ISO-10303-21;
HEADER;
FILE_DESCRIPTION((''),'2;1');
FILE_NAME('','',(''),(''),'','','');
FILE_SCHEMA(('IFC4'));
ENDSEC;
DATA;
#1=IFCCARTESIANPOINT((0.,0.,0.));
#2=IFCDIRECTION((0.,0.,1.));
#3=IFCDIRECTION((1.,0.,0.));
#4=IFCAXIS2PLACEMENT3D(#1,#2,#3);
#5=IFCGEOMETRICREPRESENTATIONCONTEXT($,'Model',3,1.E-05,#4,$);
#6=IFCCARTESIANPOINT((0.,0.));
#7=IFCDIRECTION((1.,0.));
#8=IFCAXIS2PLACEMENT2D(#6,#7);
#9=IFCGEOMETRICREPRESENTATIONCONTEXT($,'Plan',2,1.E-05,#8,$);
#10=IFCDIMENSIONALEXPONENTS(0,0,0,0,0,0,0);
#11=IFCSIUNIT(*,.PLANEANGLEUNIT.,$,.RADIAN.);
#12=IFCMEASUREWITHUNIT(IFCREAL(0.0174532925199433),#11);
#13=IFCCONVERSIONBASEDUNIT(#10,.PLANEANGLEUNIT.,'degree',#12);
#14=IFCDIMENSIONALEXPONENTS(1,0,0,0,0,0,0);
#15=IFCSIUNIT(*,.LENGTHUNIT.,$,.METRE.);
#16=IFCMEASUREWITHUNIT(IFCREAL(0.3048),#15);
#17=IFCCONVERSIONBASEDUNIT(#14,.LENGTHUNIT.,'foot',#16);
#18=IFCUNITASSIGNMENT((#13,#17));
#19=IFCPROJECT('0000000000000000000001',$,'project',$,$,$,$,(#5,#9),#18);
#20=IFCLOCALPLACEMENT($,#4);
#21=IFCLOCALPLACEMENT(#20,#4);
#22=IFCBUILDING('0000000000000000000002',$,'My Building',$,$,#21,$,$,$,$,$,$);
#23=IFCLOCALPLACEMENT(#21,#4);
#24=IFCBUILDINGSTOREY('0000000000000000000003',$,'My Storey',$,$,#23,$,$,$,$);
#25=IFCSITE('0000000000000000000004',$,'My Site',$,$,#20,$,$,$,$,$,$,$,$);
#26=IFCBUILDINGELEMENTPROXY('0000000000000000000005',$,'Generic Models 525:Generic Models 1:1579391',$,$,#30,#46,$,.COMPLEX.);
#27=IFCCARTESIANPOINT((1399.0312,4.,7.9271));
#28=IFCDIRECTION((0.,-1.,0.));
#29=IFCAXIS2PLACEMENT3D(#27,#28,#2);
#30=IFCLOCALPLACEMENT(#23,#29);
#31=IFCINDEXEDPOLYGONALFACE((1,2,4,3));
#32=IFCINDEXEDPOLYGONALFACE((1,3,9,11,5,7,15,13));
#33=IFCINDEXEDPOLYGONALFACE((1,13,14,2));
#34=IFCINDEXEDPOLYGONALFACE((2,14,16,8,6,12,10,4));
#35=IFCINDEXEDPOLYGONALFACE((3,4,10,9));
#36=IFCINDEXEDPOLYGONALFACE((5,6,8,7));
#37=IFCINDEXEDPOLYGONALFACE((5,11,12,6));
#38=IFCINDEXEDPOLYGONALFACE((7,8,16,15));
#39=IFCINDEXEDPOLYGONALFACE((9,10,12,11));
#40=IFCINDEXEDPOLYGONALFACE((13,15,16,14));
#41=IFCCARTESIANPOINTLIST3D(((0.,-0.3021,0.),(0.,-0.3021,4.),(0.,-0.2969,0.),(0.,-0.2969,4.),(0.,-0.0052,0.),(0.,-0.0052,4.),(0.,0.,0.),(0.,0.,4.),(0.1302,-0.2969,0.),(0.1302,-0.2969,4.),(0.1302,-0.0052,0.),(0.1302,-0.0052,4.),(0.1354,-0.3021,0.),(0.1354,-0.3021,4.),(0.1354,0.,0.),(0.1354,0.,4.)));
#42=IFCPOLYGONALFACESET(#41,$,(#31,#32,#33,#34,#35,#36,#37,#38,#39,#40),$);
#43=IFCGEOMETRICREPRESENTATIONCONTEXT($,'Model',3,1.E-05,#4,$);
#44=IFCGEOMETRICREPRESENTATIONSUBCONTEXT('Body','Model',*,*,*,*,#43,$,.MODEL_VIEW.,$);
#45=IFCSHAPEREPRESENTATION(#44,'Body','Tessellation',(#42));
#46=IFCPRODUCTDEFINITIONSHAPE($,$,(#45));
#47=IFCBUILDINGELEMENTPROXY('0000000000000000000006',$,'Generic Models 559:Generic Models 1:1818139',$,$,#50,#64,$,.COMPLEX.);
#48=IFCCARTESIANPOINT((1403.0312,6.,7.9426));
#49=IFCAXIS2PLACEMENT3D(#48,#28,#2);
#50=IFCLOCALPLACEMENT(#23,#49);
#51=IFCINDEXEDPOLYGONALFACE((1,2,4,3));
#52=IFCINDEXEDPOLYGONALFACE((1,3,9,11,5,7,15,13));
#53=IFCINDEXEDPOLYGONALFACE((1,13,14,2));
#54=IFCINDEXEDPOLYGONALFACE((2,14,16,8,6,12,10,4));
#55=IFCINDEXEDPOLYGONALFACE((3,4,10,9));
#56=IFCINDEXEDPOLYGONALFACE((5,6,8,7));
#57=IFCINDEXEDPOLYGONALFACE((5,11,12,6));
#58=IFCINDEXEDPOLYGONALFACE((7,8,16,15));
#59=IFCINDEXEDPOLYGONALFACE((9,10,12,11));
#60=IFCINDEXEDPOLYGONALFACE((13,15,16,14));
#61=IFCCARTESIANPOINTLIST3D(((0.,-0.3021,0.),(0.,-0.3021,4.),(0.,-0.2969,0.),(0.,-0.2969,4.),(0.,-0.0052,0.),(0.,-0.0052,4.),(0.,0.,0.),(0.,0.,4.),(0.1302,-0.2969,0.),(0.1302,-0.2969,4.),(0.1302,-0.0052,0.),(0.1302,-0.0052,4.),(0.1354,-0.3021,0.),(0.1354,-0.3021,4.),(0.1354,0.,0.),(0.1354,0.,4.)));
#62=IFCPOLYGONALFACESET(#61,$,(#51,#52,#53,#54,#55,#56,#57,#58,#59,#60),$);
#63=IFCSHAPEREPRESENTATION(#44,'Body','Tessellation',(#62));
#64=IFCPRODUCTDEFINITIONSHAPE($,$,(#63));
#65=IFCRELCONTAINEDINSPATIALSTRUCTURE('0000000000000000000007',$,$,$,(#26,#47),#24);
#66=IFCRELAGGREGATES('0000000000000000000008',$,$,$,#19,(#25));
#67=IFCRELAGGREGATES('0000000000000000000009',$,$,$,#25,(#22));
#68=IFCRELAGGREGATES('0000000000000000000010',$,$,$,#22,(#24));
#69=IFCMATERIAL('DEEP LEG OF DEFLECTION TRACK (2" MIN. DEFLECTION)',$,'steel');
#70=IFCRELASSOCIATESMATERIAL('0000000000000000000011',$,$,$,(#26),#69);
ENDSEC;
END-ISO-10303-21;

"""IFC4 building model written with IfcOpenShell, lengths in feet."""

from ifc_helpers import new_model, entity, si_unit, converted_unit, frame, origin_with_axes, origin_2d_with_axis, place, context, subcontext, project, spatial, polyline, outline, extrude, material, element, save


model = new_model("IFC4")

# Units and contexts
model_context_1 = context("Model", 3, precision=1e-05, world=origin_with_axes())
plan_context = context("Plan", 2, precision=1e-05, world=origin_2d_with_axis())
model_context_2 = context("Model", 3, precision=1e-05, world=origin_with_axes())
body_context = subcontext(model_context_2, "Body", "Model", "MODEL_VIEW")
ifc_project = project(units=[converted_unit("PLANEANGLEUNIT", "degree", entity("IfcReal", 0.0174532925199433), si_unit("PLANEANGLEUNIT", "RADIAN"), dimensions=[0, 0, 0, 0, 0, 0, 0]), converted_unit("LENGTHUNIT", "foot", entity("IfcReal", 0.3048), si_unit("LENGTHUNIT", "METRE"), dimensions=[1, 0, 0, 0, 0, 0, 0])], contexts=[model_context_1, plan_context])

# Site, building, storey
site_placement = place(None, origin_with_axes())
site = spatial("IfcSite", under=ifc_project, at=site_placement, Name="My Site")
building_placement = place(site_placement, origin_with_axes())
building = spatial("IfcBuilding", under=site, at=building_placement, Name="My Building")
storey_placement = place(building_placement, origin_with_axes())
storey = spatial("IfcBuildingStorey", under=building, at=storey_placement, Name="My Storey")

# Building element proxies
ifc_material_1 = material(Name="DEEP LEG OF DEFLECTION TRACK (2\" MIN. DEFLECTION)", Category="steel")
proxy_1_placement = place(storey_placement, frame((1399.0312, 4.0, 7.9271), z_axis=(0.0, -1.0, 0.0), x_axis=(0.0, 0.0, 1.0)))
element("IfcBuildingElementProxy", 1, at=proxy_1_placement, inside=storey, material=ifc_material_1, Name="Generic Models 525:Generic Models 1:1579391", PredefinedType="COMPLEX", context=body_context, shape_type="SweptSolid", body=[
    extrude(outline(polyline([(-0.151, -0.069), (0.151, -0.069), (0.151, 0.0664), (0.1458, 0.0664), (0.1458, -0.0638), (-0.1458, -0.0638), (-0.1458, 0.0664), (-0.151, 0.0664), (-0.151, -0.069)])), frame((0.0664, -0.151, 0.0), z_axis=(0.0, 0.0, -1.0), x_axis=(0.0, -1.0, 0.0)), (0.0, 0.0, -1.0), 4.0),
])
proxy_2_placement = place(storey_placement, frame((1403.0312, 6.0, 7.9426), z_axis=(0.0, -1.0, 0.0), x_axis=(0.0, 0.0, 1.0)))
element("IfcBuildingElementProxy", 2, at=proxy_2_placement, inside=storey, Name="Generic Models 559:Generic Models 1:1818139", PredefinedType="COMPLEX", context=body_context, shape_type="SweptSolid", body=[
    extrude(outline(polyline([(-0.069, -0.151), (0.0664, -0.151), (0.0664, -0.1458), (-0.0638, -0.1458), (-0.0638, 0.1458), (0.0664, 0.1458), (0.0664, 0.151), (-0.069, 0.151), (-0.069, -0.151)])), frame((0.0664, -0.151, 0.0), z_axis=(0.0, 0.0, -1.0), x_axis=(-1.0, 0.0, 0.0)), (0.0, 0.0, -1.0), 4.0),
])

save(model, "model.ifc")
